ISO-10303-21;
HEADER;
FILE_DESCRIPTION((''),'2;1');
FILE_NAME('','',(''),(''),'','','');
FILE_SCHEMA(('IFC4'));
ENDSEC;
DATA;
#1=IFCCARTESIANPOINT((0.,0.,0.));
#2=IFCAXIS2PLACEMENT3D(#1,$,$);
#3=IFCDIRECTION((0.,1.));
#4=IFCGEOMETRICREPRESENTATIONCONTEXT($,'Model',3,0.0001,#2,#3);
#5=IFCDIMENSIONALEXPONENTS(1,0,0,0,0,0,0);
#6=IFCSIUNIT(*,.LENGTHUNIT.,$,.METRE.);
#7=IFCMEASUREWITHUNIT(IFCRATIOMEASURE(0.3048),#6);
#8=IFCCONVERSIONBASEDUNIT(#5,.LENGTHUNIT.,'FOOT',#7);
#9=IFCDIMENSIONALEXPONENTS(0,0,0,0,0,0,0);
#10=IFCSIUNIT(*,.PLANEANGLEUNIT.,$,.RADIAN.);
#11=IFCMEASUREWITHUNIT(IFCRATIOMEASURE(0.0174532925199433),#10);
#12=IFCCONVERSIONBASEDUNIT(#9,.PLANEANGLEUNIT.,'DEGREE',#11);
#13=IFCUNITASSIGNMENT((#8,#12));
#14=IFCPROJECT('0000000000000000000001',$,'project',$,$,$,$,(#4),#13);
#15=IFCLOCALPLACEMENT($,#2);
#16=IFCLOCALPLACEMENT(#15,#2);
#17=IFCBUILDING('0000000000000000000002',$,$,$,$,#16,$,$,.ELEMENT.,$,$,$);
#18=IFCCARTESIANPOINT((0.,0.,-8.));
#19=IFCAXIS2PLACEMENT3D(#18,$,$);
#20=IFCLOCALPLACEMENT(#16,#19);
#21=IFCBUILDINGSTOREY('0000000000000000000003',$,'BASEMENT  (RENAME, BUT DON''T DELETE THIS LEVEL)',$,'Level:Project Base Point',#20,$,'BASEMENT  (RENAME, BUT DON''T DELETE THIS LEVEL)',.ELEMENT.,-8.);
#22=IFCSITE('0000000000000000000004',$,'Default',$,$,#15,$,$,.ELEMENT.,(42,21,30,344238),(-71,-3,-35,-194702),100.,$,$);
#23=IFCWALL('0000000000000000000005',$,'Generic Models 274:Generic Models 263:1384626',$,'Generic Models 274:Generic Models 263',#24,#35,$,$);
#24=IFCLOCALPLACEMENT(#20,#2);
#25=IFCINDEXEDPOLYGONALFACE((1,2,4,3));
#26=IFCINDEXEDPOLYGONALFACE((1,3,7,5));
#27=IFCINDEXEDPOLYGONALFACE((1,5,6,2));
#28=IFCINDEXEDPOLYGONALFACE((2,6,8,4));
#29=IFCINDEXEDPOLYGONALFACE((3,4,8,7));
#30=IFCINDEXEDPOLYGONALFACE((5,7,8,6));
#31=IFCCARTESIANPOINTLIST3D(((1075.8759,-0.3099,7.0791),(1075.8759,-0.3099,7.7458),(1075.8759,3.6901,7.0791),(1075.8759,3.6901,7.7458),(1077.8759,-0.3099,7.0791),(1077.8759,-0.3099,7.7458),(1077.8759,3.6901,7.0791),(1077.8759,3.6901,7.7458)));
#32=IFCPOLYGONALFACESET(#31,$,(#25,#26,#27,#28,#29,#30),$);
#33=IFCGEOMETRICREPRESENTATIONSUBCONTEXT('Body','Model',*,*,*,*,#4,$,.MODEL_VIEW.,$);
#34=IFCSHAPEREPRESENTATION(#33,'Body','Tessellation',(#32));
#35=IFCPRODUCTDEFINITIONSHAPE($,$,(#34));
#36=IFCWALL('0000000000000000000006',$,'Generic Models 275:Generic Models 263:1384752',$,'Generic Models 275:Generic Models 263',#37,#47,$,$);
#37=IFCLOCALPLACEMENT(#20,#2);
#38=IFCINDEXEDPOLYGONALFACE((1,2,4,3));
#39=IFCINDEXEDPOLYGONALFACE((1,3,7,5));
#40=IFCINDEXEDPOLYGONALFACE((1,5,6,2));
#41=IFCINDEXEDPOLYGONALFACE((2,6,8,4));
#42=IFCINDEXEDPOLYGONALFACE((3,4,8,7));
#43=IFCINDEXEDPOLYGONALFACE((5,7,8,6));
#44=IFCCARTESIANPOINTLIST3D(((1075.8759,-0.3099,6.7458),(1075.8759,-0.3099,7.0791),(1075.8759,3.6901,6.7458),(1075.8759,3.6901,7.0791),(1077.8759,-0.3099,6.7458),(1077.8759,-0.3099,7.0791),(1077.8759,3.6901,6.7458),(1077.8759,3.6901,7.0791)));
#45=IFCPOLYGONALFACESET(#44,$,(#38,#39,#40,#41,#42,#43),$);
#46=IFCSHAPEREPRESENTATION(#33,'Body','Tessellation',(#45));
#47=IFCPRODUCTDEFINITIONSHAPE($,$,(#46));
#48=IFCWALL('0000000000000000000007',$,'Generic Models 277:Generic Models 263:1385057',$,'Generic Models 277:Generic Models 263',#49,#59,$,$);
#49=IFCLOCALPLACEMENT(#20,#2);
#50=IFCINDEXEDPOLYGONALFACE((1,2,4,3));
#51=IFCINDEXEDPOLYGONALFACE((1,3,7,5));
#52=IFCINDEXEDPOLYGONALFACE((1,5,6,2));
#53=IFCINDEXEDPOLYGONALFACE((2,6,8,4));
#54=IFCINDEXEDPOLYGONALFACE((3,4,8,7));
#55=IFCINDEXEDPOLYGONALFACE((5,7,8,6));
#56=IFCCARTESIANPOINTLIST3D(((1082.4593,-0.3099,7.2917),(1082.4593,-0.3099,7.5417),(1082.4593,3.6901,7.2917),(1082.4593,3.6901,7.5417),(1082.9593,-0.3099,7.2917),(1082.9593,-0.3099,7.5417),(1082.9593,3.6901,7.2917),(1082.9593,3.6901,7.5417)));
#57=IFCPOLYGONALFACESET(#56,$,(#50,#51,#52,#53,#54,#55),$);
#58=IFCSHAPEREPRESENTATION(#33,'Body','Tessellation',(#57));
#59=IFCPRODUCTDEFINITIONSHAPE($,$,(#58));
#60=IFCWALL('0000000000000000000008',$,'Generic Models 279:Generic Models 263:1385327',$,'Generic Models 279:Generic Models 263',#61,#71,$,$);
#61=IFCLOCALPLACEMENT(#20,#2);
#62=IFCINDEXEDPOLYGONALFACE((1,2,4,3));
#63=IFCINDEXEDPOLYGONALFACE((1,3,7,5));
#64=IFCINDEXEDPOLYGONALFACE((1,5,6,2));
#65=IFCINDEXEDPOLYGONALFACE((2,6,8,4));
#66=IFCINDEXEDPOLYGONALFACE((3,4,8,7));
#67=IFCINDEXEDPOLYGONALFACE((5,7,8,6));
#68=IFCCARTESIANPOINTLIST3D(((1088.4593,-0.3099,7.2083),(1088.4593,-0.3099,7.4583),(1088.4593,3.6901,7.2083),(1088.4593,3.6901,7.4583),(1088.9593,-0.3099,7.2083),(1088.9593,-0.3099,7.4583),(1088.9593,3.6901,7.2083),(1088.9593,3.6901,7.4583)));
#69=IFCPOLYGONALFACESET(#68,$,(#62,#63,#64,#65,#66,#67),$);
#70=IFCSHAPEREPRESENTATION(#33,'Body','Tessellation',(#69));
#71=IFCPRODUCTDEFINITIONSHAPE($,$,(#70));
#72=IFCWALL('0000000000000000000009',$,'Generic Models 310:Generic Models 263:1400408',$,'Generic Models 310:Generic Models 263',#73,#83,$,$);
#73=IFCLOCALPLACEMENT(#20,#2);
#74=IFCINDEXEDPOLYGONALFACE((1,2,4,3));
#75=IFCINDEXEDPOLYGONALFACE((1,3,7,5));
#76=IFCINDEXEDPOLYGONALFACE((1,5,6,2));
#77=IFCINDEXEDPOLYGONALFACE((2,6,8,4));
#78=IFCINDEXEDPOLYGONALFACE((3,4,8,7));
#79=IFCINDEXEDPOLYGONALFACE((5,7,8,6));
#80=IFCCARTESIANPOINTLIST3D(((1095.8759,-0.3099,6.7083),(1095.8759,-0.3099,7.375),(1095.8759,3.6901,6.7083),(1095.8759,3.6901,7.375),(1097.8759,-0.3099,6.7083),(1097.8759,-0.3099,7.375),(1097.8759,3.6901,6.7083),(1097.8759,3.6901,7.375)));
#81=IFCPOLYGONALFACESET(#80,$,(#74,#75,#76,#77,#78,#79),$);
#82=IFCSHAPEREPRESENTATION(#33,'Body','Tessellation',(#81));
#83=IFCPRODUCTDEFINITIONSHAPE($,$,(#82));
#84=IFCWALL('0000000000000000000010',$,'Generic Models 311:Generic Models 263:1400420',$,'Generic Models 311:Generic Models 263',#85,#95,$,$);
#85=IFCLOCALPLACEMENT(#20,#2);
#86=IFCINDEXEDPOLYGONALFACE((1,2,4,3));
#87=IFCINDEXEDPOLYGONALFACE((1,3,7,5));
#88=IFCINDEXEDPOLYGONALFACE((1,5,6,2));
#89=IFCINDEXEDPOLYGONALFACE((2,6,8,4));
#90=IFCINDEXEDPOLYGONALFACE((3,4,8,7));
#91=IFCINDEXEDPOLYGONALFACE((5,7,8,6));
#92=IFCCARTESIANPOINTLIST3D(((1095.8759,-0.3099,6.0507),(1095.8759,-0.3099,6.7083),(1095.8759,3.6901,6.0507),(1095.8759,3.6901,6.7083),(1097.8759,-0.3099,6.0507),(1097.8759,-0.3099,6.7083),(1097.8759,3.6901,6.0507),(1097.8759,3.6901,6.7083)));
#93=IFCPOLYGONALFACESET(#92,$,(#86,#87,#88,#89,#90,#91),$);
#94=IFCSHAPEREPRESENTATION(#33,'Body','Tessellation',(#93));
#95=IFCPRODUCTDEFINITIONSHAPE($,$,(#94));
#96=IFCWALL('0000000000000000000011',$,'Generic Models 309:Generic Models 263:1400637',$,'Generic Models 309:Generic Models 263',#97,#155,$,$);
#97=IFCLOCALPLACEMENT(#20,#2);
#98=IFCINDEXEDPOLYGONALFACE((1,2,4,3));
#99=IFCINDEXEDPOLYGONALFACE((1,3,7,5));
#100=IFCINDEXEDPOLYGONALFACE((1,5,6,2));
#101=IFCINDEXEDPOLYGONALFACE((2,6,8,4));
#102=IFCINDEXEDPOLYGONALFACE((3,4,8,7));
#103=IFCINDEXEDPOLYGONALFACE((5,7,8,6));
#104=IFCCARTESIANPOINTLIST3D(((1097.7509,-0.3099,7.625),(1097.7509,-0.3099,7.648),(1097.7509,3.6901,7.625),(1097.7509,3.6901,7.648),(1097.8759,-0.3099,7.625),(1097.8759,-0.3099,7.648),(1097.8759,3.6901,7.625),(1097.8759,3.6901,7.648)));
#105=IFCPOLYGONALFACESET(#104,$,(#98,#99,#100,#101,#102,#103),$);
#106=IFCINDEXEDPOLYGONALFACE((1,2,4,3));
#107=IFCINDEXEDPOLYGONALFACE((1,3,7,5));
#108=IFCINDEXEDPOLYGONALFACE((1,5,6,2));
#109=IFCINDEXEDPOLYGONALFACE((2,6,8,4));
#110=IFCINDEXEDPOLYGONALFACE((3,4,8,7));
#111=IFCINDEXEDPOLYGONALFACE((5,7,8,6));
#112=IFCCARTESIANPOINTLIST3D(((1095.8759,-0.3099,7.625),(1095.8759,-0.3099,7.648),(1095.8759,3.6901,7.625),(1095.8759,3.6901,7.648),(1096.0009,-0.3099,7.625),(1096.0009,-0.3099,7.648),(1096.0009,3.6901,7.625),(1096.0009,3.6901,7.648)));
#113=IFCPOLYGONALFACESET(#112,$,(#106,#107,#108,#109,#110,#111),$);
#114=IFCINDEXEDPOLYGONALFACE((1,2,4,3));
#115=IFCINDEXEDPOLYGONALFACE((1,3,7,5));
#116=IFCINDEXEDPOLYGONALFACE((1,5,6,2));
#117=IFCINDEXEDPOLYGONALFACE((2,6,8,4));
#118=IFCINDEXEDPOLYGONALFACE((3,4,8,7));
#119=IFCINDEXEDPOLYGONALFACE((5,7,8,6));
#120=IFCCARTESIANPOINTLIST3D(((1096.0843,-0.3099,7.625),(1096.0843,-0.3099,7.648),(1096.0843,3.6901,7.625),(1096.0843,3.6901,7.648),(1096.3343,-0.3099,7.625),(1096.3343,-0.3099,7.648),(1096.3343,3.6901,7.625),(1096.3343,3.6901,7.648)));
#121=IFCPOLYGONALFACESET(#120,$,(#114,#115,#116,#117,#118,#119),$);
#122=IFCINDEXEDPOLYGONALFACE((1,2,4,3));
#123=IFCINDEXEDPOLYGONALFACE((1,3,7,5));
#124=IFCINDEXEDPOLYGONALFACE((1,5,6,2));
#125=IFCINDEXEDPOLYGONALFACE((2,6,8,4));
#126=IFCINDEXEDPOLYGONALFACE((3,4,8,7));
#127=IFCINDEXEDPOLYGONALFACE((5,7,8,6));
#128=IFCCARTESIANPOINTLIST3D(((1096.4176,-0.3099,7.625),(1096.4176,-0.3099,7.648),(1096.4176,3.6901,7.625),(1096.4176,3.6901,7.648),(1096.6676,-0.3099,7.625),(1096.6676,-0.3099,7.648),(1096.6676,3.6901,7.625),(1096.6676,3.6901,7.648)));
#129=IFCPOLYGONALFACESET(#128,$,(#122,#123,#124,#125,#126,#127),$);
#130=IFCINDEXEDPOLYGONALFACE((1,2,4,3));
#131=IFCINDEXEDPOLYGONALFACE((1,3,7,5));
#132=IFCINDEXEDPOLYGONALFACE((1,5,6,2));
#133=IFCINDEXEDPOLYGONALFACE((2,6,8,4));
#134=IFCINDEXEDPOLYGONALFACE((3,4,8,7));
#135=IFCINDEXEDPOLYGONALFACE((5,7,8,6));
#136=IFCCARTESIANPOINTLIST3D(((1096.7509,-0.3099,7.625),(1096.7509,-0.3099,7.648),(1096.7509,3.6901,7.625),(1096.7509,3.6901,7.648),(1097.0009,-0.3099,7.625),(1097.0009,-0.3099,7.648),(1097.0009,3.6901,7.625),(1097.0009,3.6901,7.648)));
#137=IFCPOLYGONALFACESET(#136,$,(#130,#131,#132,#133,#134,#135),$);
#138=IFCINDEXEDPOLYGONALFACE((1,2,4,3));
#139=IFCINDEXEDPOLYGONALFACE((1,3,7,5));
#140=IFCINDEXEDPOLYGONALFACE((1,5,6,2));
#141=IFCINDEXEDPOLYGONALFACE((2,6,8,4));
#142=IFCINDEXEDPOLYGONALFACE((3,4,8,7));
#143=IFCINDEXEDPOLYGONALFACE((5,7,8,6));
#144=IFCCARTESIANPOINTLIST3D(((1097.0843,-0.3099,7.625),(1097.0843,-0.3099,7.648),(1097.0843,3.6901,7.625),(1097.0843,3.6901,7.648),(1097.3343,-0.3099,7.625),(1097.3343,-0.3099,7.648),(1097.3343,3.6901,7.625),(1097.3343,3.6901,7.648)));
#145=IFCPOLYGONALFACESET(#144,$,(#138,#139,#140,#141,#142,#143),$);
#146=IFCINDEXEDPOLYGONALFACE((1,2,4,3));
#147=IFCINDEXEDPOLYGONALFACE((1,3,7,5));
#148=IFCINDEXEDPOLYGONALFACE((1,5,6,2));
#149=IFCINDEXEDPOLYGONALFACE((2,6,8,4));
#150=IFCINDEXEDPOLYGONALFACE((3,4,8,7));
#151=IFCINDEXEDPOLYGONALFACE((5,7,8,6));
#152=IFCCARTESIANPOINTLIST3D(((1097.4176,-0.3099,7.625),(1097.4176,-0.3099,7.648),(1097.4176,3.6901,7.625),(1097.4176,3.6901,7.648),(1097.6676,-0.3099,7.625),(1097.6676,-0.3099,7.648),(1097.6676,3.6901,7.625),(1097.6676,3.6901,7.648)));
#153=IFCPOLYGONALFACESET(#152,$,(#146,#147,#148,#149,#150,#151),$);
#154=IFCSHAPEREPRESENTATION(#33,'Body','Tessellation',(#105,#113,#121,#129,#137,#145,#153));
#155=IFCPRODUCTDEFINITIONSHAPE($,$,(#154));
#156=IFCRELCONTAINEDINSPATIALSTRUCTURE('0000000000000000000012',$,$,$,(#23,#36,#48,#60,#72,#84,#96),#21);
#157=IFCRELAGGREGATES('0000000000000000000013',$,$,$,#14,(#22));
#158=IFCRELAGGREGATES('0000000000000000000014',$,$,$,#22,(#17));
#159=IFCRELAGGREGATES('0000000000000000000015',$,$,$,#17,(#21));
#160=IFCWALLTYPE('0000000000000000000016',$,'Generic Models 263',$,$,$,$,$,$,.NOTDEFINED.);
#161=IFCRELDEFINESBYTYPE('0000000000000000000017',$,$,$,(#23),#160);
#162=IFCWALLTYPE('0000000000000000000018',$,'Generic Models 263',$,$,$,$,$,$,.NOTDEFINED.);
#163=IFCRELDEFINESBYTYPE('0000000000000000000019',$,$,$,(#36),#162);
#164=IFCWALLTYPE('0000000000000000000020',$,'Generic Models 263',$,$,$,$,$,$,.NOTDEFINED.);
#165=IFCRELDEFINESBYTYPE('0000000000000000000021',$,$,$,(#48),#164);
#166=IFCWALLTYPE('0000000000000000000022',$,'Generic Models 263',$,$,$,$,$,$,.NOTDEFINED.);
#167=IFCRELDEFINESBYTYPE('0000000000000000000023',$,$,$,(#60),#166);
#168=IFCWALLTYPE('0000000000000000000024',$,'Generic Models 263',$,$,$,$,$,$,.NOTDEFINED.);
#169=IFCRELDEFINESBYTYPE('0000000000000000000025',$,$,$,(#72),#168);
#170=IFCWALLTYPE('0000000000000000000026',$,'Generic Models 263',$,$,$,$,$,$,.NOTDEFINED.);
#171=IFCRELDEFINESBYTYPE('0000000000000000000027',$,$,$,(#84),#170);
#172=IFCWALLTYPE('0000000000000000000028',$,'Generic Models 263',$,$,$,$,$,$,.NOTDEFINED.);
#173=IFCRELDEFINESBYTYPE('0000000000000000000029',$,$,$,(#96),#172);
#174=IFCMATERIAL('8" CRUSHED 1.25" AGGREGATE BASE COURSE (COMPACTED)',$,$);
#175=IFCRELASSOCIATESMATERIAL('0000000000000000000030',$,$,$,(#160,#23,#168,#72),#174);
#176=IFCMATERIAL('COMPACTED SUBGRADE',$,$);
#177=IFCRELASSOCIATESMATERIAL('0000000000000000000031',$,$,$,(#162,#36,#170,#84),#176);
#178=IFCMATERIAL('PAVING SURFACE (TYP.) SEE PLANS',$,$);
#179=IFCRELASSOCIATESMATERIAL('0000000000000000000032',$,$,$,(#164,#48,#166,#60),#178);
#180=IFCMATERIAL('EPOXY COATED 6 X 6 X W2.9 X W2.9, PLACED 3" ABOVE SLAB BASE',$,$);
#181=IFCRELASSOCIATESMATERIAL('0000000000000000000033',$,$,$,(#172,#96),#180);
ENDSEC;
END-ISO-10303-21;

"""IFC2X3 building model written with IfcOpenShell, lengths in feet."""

from ifc_helpers import new_model, entity, si_unit, converted_unit, direction, frame, origin, origin_2d_with_axis, place, context, subcontext, project, spatial, rectangle, extrude, material, type_object, element, save


model = new_model("IFC2X3")

# Units and contexts
model_context = context("Model", 3, precision=0.0001, world=origin(), true_north=direction((0.0, 1.0)))
body_context = subcontext(model_context, "Body", "Model", "MODEL_VIEW")
ifc_project = project(units=[converted_unit("LENGTHUNIT", "FOOT", entity("IfcRatioMeasure", 0.3048), si_unit("LENGTHUNIT", "METRE"), dimensions=[1, 0, 0, 0, 0, 0, 0]), converted_unit("PLANEANGLEUNIT", "DEGREE", entity("IfcRatioMeasure", 0.0174532925199433), si_unit("PLANEANGLEUNIT", "RADIAN"), dimensions=[0, 0, 0, 0, 0, 0, 0])], contexts=[model_context])

# Site, building, storey
site_placement = place(None, origin())
site = spatial("IfcSite", under=ifc_project, at=site_placement, Name="Default", CompositionType="ELEMENT", RefLatitude=(42, 21, 30, 344238), RefLongitude=(-71, -3, -35, -194702), RefElevation=100.0)
building_placement = place(site_placement, origin())
building = spatial("IfcBuilding", under=site, at=building_placement, CompositionType="ELEMENT")
storey_placement = place(building_placement, frame((0.0, 0.0, -8.0)))
storey = spatial("IfcBuildingStorey", under=building, at=storey_placement, Name="BASEMENT  (RENAME, BUT DON'T DELETE THIS LEVEL)", ObjectType="Level:Project Base Point", LongName="BASEMENT  (RENAME, BUT DON'T DELETE THIS LEVEL)", CompositionType="ELEMENT", Elevation=-8.0)

# Walls
ifc_material_1 = material(Name="8\" CRUSHED 1.25\" AGGREGATE BASE COURSE (COMPACTED)")
wall_type_1 = type_object("IfcWallType", Name="Generic Models 263", PredefinedType="NOTDEFINED", material=ifc_material_1)
wall_1_placement = place(storey_placement, frame((1075.8759, -0.3099, 7.0791), z_axis=(0.0, 0.0, 1.0), x_axis=(0.0, 1.0, 0.0)))
element("IfcWall", 1, at=wall_1_placement, inside=storey, type_object=wall_type_1, material=ifc_material_1, Name="Generic Models 274:Generic Models 263:1384626", ObjectType="Generic Models 274:Generic Models 263", context=body_context, shape_type="SweptSolid", body=[
    extrude(rectangle(XDim=4.0, YDim=2.0, at=origin_2d_with_axis()), frame((2.0, -1.0, 0.0)), (0.0, 0.0, 1.0), 0.6667),
])
ifc_material_2 = material(Name="COMPACTED SUBGRADE")
wall_type_2 = type_object("IfcWallType", Name="Generic Models 263", PredefinedType="NOTDEFINED", material=ifc_material_2)
wall_2_placement = place(storey_placement, frame((1075.8759, -0.3099, 6.7458), z_axis=(0.0, 0.0, 1.0), x_axis=(0.0, 1.0, 0.0)))
element("IfcWall", 2, at=wall_2_placement, inside=storey, type_object=wall_type_2, material=ifc_material_2, Name="Generic Models 275:Generic Models 263:1384752", ObjectType="Generic Models 275:Generic Models 263", context=body_context, shape_type="SweptSolid", body=[
    extrude(rectangle(XDim=4.0, YDim=2.0, at=origin_2d_with_axis()), frame((2.0, -1.0, 0.0)), (0.0, 0.0, 1.0), 0.3333),
])
ifc_material_3 = material(Name="PAVING SURFACE (TYP.) SEE PLANS")
wall_type_3 = type_object("IfcWallType", Name="Generic Models 263", PredefinedType="NOTDEFINED", material=ifc_material_3)
wall_3_placement = place(storey_placement, frame((1082.4593, -0.3099, 7.2917), z_axis=(0.0, 0.0, 1.0), x_axis=(0.0, 1.0, 0.0)))
element("IfcWall", 3, at=wall_3_placement, inside=storey, type_object=wall_type_3, material=ifc_material_3, Name="Generic Models 277:Generic Models 263:1385057", ObjectType="Generic Models 277:Generic Models 263", context=body_context, shape_type="SweptSolid", body=[
    extrude(rectangle(XDim=4.0, YDim=0.5, at=origin_2d_with_axis()), frame((2.0, -0.25, 0.0)), (0.0, 0.0, 1.0), 0.25),
])
wall_type_4 = type_object("IfcWallType", Name="Generic Models 263", PredefinedType="NOTDEFINED", material=ifc_material_3)
wall_4_placement = place(storey_placement, frame((1088.4593, -0.3099, 7.2083), z_axis=(0.0, 0.0, 1.0), x_axis=(0.0, 1.0, 0.0)))
element("IfcWall", 4, at=wall_4_placement, inside=storey, type_object=wall_type_4, material=ifc_material_3, Name="Generic Models 279:Generic Models 263:1385327", ObjectType="Generic Models 279:Generic Models 263", context=body_context, shape_type="SweptSolid", body=[
    extrude(rectangle(XDim=4.0, YDim=0.5, at=origin_2d_with_axis()), frame((2.0, -0.25, 0.0)), (0.0, 0.0, 1.0), 0.25),
])
wall_type_5 = type_object("IfcWallType", Name="Generic Models 263", PredefinedType="NOTDEFINED", material=ifc_material_1)
wall_5_placement = place(storey_placement, frame((1095.8759, -0.3099, 6.7083), z_axis=(0.0, 0.0, 1.0), x_axis=(0.0, 1.0, 0.0)))
element("IfcWall", 5, at=wall_5_placement, inside=storey, type_object=wall_type_5, material=ifc_material_1, Name="Generic Models 310:Generic Models 263:1400408", ObjectType="Generic Models 310:Generic Models 263", context=body_context, shape_type="SweptSolid", body=[
    extrude(rectangle(XDim=4.0, YDim=2.0, at=origin_2d_with_axis()), frame((2.0, -1.0, 0.0)), (0.0, 0.0, 1.0), 0.6667),
])
wall_type_6 = type_object("IfcWallType", Name="Generic Models 263", PredefinedType="NOTDEFINED", material=ifc_material_2)
wall_6_placement = place(storey_placement, frame((1095.8759, -0.3099, 6.0507), z_axis=(0.0, 0.0, 1.0), x_axis=(0.0, 1.0, 0.0)))
element("IfcWall", 6, at=wall_6_placement, inside=storey, type_object=wall_type_6, material=ifc_material_2, Name="Generic Models 311:Generic Models 263:1400420", ObjectType="Generic Models 311:Generic Models 263", context=body_context, shape_type="SweptSolid", body=[
    extrude(rectangle(XDim=4.0, YDim=2.0, at=origin_2d_with_axis()), frame((2.0, -1.0, 0.0)), (0.0, 0.0, 1.0), 0.6576),
])
ifc_material_4 = material(Name="EPOXY COATED 6 X 6 X W2.9 X W2.9, PLACED 3\" ABOVE SLAB BASE")
wall_type_7 = type_object("IfcWallType", Name="Generic Models 263", PredefinedType="NOTDEFINED", material=ifc_material_4)
wall_7_placement = place(storey_placement, frame((1095.8759, -0.3099, 7.625), z_axis=(0.0, 0.0, 1.0), x_axis=(0.0, 1.0, 0.0)))
element("IfcWall", 7, at=wall_7_placement, inside=storey, type_object=wall_type_7, material=ifc_material_4, Name="Generic Models 309:Generic Models 263:1400637", ObjectType="Generic Models 309:Generic Models 263", context=body_context, shape_type="SweptSolid", body=[
    extrude(rectangle(XDim=4.0, YDim=0.125, at=origin_2d_with_axis()), frame((2.0, -1.9375, 0.0)), (0.0, 0.0, 1.0), 0.023),
    extrude(rectangle(XDim=4.0, YDim=0.125, at=origin_2d_with_axis()), frame((2.0, -0.0625, 0.0)), (0.0, 0.0, 1.0), 0.023),
    extrude(rectangle(XDim=4.0, YDim=0.25, at=origin_2d_with_axis()), frame((2.0, -0.3333, 0.0)), (0.0, 0.0, 1.0), 0.023),
    extrude(rectangle(XDim=4.0, YDim=0.25, at=origin_2d_with_axis()), frame((2.0, -0.6667, 0.0)), (0.0, 0.0, 1.0), 0.023),
    extrude(rectangle(XDim=4.0, YDim=0.25, at=origin_2d_with_axis()), frame((2.0, -1.0, 0.0)), (0.0, 0.0, 1.0), 0.023),
    extrude(rectangle(XDim=4.0, YDim=0.25, at=origin_2d_with_axis()), frame((2.0, -1.3333, 0.0)), (0.0, 0.0, 1.0), 0.023),
    extrude(rectangle(XDim=4.0, YDim=0.25, at=origin_2d_with_axis()), frame((2.0, -1.6667, 0.0)), (0.0, 0.0, 1.0), 0.023),
])

save(model, "model.ifc")
